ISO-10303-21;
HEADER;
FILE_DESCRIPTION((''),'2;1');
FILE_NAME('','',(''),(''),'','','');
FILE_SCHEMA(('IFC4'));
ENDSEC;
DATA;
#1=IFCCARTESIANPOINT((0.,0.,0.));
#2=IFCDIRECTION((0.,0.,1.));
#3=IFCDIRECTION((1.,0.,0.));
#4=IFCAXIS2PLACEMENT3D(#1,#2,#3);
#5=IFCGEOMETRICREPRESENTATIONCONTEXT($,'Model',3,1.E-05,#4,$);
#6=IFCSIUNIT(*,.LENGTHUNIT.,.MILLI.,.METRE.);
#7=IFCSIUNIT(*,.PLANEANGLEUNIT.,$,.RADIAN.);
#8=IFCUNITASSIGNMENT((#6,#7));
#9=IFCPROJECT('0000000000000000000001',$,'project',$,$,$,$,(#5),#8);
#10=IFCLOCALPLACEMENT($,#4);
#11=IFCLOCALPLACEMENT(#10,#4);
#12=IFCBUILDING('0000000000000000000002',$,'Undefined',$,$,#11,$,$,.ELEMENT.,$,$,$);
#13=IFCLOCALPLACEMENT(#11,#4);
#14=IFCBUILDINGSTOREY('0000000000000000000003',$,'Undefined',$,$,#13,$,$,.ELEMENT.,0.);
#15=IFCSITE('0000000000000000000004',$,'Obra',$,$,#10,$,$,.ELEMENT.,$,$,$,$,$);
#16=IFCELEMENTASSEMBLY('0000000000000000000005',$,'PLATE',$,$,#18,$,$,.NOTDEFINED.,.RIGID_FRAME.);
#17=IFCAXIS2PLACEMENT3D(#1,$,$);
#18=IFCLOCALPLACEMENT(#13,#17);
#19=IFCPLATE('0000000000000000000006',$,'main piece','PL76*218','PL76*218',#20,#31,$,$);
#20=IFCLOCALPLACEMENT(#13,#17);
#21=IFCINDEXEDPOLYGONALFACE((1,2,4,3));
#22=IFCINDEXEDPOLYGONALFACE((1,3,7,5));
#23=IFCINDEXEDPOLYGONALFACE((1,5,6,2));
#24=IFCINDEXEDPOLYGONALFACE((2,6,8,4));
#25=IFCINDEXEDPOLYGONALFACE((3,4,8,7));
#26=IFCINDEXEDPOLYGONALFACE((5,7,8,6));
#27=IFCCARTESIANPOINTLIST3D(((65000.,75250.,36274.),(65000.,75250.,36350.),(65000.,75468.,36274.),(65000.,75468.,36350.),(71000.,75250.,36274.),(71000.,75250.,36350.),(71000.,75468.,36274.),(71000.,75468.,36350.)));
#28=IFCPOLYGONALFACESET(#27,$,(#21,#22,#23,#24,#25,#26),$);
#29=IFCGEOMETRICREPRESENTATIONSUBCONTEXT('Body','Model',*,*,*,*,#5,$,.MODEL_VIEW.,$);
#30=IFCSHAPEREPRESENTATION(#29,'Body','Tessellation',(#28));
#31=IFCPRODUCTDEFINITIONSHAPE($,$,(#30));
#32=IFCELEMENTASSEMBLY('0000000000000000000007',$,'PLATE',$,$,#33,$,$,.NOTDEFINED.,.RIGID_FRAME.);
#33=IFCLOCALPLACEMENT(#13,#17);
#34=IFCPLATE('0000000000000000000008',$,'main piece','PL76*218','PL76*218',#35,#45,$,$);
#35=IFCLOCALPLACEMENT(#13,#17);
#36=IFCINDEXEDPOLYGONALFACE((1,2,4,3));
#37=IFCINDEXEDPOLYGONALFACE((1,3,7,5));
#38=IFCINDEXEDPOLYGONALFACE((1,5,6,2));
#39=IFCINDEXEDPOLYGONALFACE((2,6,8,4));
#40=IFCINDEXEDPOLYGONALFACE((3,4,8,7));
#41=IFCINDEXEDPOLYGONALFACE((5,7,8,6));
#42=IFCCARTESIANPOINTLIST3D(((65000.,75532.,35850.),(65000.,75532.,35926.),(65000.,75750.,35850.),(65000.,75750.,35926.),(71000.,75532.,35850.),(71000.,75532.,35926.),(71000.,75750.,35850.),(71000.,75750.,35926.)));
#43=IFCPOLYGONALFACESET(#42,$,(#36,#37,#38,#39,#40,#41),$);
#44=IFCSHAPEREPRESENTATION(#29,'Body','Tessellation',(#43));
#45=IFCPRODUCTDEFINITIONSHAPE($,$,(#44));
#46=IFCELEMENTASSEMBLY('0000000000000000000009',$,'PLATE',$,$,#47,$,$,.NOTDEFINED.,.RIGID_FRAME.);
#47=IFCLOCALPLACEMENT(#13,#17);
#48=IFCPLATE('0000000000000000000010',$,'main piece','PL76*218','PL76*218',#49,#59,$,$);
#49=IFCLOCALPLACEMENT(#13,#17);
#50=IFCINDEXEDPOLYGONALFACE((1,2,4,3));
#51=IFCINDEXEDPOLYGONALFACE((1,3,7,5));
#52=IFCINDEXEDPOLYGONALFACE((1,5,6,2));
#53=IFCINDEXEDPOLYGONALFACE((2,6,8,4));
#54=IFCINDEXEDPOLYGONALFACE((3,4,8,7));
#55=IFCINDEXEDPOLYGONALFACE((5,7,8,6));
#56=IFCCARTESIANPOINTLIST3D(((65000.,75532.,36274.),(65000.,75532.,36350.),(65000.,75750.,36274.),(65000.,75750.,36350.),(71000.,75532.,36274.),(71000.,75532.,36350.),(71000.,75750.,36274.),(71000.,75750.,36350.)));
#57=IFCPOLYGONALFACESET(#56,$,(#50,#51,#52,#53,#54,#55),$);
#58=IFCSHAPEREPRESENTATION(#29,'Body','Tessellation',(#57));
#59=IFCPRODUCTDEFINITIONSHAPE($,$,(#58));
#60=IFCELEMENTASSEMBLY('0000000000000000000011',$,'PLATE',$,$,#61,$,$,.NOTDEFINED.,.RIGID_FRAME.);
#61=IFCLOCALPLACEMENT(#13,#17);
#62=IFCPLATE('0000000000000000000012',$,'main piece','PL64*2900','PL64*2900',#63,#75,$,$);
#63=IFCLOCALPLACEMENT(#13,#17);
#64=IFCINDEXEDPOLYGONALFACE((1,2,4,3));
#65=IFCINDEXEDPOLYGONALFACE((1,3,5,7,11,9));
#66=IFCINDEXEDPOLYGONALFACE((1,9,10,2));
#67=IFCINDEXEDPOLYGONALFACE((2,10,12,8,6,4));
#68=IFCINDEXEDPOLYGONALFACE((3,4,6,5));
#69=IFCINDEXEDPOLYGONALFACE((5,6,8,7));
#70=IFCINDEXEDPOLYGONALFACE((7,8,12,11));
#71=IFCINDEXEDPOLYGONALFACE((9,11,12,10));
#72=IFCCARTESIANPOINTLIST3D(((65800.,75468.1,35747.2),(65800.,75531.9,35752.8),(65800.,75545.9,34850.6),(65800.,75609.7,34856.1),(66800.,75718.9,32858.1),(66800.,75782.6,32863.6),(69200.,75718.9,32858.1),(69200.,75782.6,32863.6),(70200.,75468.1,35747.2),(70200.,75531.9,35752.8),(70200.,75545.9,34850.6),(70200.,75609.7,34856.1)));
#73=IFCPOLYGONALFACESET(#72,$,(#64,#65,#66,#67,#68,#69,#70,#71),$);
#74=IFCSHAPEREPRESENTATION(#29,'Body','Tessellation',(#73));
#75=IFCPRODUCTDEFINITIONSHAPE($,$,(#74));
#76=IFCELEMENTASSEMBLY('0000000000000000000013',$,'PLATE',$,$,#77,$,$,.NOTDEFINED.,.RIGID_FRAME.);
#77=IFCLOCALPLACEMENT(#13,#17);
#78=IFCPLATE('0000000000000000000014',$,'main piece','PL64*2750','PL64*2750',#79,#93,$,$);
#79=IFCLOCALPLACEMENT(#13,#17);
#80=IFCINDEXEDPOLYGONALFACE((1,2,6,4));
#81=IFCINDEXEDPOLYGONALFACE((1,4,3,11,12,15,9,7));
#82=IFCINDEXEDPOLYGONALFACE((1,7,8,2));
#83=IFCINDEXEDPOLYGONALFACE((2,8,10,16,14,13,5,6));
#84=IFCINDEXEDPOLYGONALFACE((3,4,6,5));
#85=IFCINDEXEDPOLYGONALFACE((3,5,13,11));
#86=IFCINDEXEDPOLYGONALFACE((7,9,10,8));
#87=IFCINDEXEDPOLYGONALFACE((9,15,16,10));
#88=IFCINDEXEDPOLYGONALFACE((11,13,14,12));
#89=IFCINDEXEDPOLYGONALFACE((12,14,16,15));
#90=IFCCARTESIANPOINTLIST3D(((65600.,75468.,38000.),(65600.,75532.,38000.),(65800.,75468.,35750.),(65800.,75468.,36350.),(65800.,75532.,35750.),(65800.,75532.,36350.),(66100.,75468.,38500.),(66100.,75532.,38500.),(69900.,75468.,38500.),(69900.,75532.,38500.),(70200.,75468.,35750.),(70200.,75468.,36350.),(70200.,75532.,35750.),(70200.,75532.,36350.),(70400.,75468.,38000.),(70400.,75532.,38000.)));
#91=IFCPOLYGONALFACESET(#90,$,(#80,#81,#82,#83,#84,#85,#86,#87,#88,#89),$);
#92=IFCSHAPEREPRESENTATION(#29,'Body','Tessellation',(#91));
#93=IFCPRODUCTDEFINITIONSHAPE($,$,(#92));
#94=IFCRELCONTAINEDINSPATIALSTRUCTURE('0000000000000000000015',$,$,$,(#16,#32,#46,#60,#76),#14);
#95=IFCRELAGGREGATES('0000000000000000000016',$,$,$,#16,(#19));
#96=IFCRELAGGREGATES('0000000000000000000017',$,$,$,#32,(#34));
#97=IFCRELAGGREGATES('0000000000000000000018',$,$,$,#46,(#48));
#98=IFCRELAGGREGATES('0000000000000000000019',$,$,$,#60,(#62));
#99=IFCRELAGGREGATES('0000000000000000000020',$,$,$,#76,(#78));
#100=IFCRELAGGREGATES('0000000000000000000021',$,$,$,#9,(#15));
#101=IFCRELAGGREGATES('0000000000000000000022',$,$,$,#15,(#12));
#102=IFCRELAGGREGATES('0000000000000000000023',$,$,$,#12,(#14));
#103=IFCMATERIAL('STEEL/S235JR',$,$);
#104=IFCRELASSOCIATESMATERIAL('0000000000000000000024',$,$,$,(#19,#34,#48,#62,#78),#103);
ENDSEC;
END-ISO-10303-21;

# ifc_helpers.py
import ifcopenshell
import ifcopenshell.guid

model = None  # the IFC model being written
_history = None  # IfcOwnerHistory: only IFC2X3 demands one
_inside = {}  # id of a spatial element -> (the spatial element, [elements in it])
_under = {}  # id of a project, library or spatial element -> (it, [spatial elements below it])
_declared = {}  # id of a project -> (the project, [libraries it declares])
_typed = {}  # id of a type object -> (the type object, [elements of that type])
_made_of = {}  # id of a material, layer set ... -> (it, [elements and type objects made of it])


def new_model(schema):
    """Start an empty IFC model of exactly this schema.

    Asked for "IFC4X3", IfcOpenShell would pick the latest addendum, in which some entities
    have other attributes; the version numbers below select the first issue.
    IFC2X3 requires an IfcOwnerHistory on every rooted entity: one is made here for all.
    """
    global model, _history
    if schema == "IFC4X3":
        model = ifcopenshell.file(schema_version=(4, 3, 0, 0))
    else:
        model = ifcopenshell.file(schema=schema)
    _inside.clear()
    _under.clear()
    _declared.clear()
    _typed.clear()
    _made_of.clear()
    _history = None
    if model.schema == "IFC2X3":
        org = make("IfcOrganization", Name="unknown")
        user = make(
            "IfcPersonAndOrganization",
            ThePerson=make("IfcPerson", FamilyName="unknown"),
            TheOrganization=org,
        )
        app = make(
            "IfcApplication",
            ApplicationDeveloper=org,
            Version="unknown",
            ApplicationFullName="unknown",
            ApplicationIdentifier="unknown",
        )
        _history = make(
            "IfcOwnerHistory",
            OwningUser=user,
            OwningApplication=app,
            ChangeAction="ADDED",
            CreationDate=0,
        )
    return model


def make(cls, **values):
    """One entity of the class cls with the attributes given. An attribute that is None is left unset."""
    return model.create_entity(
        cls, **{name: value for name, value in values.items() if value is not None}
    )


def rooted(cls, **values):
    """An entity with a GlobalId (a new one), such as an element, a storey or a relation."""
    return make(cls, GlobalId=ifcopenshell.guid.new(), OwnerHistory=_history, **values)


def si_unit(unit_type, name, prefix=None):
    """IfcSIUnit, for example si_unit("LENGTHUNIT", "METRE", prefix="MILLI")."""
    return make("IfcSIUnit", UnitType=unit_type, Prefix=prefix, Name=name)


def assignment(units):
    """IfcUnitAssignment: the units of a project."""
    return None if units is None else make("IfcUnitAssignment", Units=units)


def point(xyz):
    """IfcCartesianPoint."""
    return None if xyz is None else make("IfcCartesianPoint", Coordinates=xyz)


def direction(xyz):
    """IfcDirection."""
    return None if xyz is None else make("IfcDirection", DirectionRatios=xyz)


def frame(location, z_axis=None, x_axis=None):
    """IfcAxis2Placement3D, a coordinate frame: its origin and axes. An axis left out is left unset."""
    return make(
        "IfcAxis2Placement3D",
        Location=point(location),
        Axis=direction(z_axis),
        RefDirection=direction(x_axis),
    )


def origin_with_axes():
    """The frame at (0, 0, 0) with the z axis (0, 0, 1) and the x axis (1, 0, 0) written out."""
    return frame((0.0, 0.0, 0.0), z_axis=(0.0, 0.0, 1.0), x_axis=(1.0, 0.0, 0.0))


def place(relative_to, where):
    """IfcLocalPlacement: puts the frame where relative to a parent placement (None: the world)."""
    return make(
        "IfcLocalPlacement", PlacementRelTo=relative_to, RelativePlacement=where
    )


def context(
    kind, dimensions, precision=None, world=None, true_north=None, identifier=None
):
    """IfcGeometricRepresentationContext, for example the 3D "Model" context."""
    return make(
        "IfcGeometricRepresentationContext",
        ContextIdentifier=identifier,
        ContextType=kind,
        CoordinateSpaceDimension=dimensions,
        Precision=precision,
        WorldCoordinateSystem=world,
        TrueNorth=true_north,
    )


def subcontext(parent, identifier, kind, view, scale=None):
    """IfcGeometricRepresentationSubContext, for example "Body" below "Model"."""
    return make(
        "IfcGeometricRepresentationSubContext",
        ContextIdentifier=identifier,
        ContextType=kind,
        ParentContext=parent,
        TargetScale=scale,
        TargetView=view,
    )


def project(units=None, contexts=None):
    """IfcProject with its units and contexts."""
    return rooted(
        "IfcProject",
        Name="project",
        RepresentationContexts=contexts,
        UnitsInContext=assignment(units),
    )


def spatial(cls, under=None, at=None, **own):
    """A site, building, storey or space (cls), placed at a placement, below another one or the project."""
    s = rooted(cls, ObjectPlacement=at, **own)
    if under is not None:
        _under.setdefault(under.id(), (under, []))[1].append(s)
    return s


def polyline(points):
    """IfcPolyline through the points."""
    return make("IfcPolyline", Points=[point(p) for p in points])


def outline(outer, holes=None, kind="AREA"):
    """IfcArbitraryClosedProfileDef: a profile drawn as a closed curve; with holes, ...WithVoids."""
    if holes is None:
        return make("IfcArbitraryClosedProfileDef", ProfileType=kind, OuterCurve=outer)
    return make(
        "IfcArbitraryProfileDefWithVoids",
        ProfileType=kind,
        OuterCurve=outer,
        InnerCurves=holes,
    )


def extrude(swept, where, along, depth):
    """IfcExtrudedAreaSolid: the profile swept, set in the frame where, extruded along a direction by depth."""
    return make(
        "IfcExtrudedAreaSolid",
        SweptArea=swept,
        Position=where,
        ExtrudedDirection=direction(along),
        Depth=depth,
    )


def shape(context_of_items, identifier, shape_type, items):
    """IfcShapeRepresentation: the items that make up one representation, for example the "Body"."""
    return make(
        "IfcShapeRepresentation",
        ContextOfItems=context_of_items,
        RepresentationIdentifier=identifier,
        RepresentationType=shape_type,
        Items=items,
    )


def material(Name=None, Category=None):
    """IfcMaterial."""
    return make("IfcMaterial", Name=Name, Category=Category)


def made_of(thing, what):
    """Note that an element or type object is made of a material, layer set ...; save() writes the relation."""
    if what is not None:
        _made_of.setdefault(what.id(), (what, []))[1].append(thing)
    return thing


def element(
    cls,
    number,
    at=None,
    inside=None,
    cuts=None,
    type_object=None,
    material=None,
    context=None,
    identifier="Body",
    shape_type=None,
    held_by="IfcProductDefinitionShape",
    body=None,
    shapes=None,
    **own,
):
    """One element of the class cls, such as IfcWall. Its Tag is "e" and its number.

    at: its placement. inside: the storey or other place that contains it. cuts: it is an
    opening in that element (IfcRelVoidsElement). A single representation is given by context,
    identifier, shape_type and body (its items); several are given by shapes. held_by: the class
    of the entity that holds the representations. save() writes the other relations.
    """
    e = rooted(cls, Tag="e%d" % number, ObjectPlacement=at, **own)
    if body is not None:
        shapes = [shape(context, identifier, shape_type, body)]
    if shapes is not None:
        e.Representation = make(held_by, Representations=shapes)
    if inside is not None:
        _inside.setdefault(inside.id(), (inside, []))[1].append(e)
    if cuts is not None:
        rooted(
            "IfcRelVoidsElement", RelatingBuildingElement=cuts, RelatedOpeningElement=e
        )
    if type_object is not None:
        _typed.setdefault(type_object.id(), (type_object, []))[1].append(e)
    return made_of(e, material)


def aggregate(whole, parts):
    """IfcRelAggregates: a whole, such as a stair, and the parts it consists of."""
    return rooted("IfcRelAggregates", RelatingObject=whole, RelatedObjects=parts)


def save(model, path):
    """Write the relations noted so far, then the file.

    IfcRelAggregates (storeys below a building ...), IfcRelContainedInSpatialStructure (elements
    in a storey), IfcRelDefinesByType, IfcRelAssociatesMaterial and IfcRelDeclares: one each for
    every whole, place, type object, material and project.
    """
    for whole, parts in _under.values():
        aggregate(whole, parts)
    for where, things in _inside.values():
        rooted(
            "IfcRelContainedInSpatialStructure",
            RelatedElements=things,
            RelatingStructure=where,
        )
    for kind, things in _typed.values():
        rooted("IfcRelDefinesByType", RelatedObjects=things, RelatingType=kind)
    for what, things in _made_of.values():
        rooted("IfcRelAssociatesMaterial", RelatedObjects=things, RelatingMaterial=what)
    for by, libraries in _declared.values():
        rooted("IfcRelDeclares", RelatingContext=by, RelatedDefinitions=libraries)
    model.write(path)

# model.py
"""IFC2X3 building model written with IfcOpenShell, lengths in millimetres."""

from ifc_helpers import new_model, si_unit, frame, origin_with_axes, place, context, subcontext, project, spatial, polyline, outline, extrude, material, element, aggregate, save


model = new_model("IFC2X3")

# Units and contexts
model_context = context("Model", 3, precision=1e-05, world=origin_with_axes())
body_context = subcontext(model_context, "Body", "Model", "MODEL_VIEW")
ifc_project = project(units=[si_unit("LENGTHUNIT", "METRE", prefix="MILLI"), si_unit("PLANEANGLEUNIT", "RADIAN")], contexts=[model_context])

# Site, building, storey
site_placement = place(None, origin_with_axes())
site = spatial("IfcSite", under=ifc_project, at=site_placement, Name="Obra", CompositionType="ELEMENT")
building_placement = place(site_placement, origin_with_axes())
building = spatial("IfcBuilding", under=site, at=building_placement, Name="Undefined", CompositionType="ELEMENT")
storey_placement = place(building_placement, origin_with_axes())
storey = spatial("IfcBuildingStorey", under=building, at=storey_placement, Name="Undefined", CompositionType="ELEMENT", Elevation=0.0)

# Shared definitions
ifc_material = material(Name="STEEL/S235JR")

# Element assemblies, plates
assembly_1_placement = place(storey_placement, origin_with_axes())
assembly_1 = element("IfcElementAssembly", 1, at=assembly_1_placement, inside=storey, Name="PLATE", AssemblyPlace="NOTDEFINED", PredefinedType="RIGID_FRAME")
plate_1_placement = place(assembly_1_placement, frame((65000.0, 75250.0, 36312.0), z_axis=(0.0, 0.0, -1.0), x_axis=(0.0, 1.0, 0.0)))
plate_1 = element("IfcPlate", 2, at=plate_1_placement, material=ifc_material, Name="main piece", Description="PL76*218", ObjectType="PL76*218", context=body_context, shape_type="SweptSolid", body=[
    extrude(outline(polyline([(0.0, 0.0), (218.0, 0.0), (218.0, 6000.0), (0.0, 6000.0), (0.0, 0.0)])), frame((0.0, 0.0, -38.0), z_axis=(0.0, 0.0, 1.0), x_axis=(1.0, 0.0, 0.0)), (0.0, 0.0, 1.0), 76.0),
])
aggregate(assembly_1, [plate_1])
assembly_2_placement = place(storey_placement, origin_with_axes())
assembly_2 = element("IfcElementAssembly", 3, at=assembly_2_placement, inside=storey, Name="PLATE", AssemblyPlace="NOTDEFINED", PredefinedType="RIGID_FRAME")
plate_2_placement = place(assembly_2_placement, frame((65000.0, 75750.0, 35888.0), z_axis=(0.0, 0.0, 1.0), x_axis=(0.0, -1.0, 0.0)))
plate_2 = element("IfcPlate", 4, at=plate_2_placement, material=ifc_material, Name="main piece", Description="PL76*218", ObjectType="PL76*218", context=body_context, shape_type="SweptSolid", body=[
    extrude(outline(polyline([(0.0, 0.0), (218.0, 0.0), (218.0, 6000.0), (0.0, 6000.0), (0.0, 0.0)])), frame((0.0, 0.0, -38.0), z_axis=(0.0, 0.0, 1.0), x_axis=(1.0, 0.0, 0.0)), (0.0, 0.0, 1.0), 76.0),
])
aggregate(assembly_2, [plate_2])
assembly_3_placement = place(storey_placement, origin_with_axes())
assembly_3 = element("IfcElementAssembly", 5, at=assembly_3_placement, inside=storey, Name="PLATE", AssemblyPlace="NOTDEFINED", PredefinedType="RIGID_FRAME")
plate_3_placement = place(assembly_3_placement, frame((65000.0, 75750.0, 36312.0), z_axis=(0.0, 0.0, 1.0), x_axis=(0.0, -1.0, 0.0)))
plate_3 = element("IfcPlate", 6, at=plate_3_placement, material=ifc_material, Name="main piece", Description="PL76*218", ObjectType="PL76*218", context=body_context, shape_type="SweptSolid", body=[
    extrude(outline(polyline([(0.0, 0.0), (218.0, 0.0), (218.0, 6000.0), (0.0, 6000.0), (0.0, 0.0)])), frame((0.0, 0.0, -38.0), z_axis=(0.0, 0.0, 1.0), x_axis=(1.0, 0.0, 0.0)), (0.0, 0.0, 1.0), 76.0),
])
aggregate(assembly_3, [plate_3])
assembly_4_placement = place(storey_placement, origin_with_axes())
assembly_4 = element("IfcElementAssembly", 7, at=assembly_4_placement, inside=storey, Name="PLATE", AssemblyPlace="NOTDEFINED", PredefinedType="RIGID_FRAME")
plate_4_placement = place(assembly_4_placement, frame((70200.0, 75500.0, 35750.0), z_axis=(0.0, -0.996255, -0.08646), x_axis=(-1.0, 0.0, 0.0)))
plate_4 = element("IfcPlate", 8, at=plate_4_placement, material=ifc_material, Name="main piece", Description="PL64*2900", ObjectType="PL64*2900", context=body_context, shape_type="SweptSolid", body=[
    extrude(outline(polyline([(0.0, 0.0), (4400.0, 0.0), (4400.0, 900.0), (3400.0, 2900.0), (1000.0, 2900.0), (0.0, 900.0), (0.0, 0.0)])), frame((0.0, 0.0, -32.0), z_axis=(0.0, 0.0, 1.0), x_axis=(1.0, 0.0, 0.0)), (0.0, 0.0, 1.0), 64.0),
])
aggregate(assembly_4, [plate_4])
assembly_5_placement = place(storey_placement, origin_with_axes())
assembly_5 = element("IfcElementAssembly", 9, at=assembly_5_placement, inside=storey, Name="PLATE", AssemblyPlace="NOTDEFINED", PredefinedType="RIGID_FRAME")
plate_5_placement = place(assembly_5_placement, frame((65800.0, 75500.0, 35750.0), z_axis=(0.0, -1.0, 0.0), x_axis=(1.0, 0.0, 0.0)))
plate_5 = element("IfcPlate", 10, at=plate_5_placement, material=ifc_material, Name="main piece", Description="PL64*2750", ObjectType="PL64*2750", context=body_context, shape_type="SweptSolid", body=[
    extrude(outline(polyline([(0.0, 0.0), (4400.0, 0.0), (4400.0, 600.0), (4600.0, 2250.0), (4100.0, 2750.0), (300.0, 2750.0), (-200.0, 2250.0), (0.0, 600.0), (0.0, 0.0)])), frame((0.0, 0.0, -32.0), z_axis=(0.0, 0.0, 1.0), x_axis=(1.0, 0.0, 0.0)), (0.0, 0.0, 1.0), 64.0),
])
aggregate(assembly_5, [plate_5])

save(model, "model.ifc")
